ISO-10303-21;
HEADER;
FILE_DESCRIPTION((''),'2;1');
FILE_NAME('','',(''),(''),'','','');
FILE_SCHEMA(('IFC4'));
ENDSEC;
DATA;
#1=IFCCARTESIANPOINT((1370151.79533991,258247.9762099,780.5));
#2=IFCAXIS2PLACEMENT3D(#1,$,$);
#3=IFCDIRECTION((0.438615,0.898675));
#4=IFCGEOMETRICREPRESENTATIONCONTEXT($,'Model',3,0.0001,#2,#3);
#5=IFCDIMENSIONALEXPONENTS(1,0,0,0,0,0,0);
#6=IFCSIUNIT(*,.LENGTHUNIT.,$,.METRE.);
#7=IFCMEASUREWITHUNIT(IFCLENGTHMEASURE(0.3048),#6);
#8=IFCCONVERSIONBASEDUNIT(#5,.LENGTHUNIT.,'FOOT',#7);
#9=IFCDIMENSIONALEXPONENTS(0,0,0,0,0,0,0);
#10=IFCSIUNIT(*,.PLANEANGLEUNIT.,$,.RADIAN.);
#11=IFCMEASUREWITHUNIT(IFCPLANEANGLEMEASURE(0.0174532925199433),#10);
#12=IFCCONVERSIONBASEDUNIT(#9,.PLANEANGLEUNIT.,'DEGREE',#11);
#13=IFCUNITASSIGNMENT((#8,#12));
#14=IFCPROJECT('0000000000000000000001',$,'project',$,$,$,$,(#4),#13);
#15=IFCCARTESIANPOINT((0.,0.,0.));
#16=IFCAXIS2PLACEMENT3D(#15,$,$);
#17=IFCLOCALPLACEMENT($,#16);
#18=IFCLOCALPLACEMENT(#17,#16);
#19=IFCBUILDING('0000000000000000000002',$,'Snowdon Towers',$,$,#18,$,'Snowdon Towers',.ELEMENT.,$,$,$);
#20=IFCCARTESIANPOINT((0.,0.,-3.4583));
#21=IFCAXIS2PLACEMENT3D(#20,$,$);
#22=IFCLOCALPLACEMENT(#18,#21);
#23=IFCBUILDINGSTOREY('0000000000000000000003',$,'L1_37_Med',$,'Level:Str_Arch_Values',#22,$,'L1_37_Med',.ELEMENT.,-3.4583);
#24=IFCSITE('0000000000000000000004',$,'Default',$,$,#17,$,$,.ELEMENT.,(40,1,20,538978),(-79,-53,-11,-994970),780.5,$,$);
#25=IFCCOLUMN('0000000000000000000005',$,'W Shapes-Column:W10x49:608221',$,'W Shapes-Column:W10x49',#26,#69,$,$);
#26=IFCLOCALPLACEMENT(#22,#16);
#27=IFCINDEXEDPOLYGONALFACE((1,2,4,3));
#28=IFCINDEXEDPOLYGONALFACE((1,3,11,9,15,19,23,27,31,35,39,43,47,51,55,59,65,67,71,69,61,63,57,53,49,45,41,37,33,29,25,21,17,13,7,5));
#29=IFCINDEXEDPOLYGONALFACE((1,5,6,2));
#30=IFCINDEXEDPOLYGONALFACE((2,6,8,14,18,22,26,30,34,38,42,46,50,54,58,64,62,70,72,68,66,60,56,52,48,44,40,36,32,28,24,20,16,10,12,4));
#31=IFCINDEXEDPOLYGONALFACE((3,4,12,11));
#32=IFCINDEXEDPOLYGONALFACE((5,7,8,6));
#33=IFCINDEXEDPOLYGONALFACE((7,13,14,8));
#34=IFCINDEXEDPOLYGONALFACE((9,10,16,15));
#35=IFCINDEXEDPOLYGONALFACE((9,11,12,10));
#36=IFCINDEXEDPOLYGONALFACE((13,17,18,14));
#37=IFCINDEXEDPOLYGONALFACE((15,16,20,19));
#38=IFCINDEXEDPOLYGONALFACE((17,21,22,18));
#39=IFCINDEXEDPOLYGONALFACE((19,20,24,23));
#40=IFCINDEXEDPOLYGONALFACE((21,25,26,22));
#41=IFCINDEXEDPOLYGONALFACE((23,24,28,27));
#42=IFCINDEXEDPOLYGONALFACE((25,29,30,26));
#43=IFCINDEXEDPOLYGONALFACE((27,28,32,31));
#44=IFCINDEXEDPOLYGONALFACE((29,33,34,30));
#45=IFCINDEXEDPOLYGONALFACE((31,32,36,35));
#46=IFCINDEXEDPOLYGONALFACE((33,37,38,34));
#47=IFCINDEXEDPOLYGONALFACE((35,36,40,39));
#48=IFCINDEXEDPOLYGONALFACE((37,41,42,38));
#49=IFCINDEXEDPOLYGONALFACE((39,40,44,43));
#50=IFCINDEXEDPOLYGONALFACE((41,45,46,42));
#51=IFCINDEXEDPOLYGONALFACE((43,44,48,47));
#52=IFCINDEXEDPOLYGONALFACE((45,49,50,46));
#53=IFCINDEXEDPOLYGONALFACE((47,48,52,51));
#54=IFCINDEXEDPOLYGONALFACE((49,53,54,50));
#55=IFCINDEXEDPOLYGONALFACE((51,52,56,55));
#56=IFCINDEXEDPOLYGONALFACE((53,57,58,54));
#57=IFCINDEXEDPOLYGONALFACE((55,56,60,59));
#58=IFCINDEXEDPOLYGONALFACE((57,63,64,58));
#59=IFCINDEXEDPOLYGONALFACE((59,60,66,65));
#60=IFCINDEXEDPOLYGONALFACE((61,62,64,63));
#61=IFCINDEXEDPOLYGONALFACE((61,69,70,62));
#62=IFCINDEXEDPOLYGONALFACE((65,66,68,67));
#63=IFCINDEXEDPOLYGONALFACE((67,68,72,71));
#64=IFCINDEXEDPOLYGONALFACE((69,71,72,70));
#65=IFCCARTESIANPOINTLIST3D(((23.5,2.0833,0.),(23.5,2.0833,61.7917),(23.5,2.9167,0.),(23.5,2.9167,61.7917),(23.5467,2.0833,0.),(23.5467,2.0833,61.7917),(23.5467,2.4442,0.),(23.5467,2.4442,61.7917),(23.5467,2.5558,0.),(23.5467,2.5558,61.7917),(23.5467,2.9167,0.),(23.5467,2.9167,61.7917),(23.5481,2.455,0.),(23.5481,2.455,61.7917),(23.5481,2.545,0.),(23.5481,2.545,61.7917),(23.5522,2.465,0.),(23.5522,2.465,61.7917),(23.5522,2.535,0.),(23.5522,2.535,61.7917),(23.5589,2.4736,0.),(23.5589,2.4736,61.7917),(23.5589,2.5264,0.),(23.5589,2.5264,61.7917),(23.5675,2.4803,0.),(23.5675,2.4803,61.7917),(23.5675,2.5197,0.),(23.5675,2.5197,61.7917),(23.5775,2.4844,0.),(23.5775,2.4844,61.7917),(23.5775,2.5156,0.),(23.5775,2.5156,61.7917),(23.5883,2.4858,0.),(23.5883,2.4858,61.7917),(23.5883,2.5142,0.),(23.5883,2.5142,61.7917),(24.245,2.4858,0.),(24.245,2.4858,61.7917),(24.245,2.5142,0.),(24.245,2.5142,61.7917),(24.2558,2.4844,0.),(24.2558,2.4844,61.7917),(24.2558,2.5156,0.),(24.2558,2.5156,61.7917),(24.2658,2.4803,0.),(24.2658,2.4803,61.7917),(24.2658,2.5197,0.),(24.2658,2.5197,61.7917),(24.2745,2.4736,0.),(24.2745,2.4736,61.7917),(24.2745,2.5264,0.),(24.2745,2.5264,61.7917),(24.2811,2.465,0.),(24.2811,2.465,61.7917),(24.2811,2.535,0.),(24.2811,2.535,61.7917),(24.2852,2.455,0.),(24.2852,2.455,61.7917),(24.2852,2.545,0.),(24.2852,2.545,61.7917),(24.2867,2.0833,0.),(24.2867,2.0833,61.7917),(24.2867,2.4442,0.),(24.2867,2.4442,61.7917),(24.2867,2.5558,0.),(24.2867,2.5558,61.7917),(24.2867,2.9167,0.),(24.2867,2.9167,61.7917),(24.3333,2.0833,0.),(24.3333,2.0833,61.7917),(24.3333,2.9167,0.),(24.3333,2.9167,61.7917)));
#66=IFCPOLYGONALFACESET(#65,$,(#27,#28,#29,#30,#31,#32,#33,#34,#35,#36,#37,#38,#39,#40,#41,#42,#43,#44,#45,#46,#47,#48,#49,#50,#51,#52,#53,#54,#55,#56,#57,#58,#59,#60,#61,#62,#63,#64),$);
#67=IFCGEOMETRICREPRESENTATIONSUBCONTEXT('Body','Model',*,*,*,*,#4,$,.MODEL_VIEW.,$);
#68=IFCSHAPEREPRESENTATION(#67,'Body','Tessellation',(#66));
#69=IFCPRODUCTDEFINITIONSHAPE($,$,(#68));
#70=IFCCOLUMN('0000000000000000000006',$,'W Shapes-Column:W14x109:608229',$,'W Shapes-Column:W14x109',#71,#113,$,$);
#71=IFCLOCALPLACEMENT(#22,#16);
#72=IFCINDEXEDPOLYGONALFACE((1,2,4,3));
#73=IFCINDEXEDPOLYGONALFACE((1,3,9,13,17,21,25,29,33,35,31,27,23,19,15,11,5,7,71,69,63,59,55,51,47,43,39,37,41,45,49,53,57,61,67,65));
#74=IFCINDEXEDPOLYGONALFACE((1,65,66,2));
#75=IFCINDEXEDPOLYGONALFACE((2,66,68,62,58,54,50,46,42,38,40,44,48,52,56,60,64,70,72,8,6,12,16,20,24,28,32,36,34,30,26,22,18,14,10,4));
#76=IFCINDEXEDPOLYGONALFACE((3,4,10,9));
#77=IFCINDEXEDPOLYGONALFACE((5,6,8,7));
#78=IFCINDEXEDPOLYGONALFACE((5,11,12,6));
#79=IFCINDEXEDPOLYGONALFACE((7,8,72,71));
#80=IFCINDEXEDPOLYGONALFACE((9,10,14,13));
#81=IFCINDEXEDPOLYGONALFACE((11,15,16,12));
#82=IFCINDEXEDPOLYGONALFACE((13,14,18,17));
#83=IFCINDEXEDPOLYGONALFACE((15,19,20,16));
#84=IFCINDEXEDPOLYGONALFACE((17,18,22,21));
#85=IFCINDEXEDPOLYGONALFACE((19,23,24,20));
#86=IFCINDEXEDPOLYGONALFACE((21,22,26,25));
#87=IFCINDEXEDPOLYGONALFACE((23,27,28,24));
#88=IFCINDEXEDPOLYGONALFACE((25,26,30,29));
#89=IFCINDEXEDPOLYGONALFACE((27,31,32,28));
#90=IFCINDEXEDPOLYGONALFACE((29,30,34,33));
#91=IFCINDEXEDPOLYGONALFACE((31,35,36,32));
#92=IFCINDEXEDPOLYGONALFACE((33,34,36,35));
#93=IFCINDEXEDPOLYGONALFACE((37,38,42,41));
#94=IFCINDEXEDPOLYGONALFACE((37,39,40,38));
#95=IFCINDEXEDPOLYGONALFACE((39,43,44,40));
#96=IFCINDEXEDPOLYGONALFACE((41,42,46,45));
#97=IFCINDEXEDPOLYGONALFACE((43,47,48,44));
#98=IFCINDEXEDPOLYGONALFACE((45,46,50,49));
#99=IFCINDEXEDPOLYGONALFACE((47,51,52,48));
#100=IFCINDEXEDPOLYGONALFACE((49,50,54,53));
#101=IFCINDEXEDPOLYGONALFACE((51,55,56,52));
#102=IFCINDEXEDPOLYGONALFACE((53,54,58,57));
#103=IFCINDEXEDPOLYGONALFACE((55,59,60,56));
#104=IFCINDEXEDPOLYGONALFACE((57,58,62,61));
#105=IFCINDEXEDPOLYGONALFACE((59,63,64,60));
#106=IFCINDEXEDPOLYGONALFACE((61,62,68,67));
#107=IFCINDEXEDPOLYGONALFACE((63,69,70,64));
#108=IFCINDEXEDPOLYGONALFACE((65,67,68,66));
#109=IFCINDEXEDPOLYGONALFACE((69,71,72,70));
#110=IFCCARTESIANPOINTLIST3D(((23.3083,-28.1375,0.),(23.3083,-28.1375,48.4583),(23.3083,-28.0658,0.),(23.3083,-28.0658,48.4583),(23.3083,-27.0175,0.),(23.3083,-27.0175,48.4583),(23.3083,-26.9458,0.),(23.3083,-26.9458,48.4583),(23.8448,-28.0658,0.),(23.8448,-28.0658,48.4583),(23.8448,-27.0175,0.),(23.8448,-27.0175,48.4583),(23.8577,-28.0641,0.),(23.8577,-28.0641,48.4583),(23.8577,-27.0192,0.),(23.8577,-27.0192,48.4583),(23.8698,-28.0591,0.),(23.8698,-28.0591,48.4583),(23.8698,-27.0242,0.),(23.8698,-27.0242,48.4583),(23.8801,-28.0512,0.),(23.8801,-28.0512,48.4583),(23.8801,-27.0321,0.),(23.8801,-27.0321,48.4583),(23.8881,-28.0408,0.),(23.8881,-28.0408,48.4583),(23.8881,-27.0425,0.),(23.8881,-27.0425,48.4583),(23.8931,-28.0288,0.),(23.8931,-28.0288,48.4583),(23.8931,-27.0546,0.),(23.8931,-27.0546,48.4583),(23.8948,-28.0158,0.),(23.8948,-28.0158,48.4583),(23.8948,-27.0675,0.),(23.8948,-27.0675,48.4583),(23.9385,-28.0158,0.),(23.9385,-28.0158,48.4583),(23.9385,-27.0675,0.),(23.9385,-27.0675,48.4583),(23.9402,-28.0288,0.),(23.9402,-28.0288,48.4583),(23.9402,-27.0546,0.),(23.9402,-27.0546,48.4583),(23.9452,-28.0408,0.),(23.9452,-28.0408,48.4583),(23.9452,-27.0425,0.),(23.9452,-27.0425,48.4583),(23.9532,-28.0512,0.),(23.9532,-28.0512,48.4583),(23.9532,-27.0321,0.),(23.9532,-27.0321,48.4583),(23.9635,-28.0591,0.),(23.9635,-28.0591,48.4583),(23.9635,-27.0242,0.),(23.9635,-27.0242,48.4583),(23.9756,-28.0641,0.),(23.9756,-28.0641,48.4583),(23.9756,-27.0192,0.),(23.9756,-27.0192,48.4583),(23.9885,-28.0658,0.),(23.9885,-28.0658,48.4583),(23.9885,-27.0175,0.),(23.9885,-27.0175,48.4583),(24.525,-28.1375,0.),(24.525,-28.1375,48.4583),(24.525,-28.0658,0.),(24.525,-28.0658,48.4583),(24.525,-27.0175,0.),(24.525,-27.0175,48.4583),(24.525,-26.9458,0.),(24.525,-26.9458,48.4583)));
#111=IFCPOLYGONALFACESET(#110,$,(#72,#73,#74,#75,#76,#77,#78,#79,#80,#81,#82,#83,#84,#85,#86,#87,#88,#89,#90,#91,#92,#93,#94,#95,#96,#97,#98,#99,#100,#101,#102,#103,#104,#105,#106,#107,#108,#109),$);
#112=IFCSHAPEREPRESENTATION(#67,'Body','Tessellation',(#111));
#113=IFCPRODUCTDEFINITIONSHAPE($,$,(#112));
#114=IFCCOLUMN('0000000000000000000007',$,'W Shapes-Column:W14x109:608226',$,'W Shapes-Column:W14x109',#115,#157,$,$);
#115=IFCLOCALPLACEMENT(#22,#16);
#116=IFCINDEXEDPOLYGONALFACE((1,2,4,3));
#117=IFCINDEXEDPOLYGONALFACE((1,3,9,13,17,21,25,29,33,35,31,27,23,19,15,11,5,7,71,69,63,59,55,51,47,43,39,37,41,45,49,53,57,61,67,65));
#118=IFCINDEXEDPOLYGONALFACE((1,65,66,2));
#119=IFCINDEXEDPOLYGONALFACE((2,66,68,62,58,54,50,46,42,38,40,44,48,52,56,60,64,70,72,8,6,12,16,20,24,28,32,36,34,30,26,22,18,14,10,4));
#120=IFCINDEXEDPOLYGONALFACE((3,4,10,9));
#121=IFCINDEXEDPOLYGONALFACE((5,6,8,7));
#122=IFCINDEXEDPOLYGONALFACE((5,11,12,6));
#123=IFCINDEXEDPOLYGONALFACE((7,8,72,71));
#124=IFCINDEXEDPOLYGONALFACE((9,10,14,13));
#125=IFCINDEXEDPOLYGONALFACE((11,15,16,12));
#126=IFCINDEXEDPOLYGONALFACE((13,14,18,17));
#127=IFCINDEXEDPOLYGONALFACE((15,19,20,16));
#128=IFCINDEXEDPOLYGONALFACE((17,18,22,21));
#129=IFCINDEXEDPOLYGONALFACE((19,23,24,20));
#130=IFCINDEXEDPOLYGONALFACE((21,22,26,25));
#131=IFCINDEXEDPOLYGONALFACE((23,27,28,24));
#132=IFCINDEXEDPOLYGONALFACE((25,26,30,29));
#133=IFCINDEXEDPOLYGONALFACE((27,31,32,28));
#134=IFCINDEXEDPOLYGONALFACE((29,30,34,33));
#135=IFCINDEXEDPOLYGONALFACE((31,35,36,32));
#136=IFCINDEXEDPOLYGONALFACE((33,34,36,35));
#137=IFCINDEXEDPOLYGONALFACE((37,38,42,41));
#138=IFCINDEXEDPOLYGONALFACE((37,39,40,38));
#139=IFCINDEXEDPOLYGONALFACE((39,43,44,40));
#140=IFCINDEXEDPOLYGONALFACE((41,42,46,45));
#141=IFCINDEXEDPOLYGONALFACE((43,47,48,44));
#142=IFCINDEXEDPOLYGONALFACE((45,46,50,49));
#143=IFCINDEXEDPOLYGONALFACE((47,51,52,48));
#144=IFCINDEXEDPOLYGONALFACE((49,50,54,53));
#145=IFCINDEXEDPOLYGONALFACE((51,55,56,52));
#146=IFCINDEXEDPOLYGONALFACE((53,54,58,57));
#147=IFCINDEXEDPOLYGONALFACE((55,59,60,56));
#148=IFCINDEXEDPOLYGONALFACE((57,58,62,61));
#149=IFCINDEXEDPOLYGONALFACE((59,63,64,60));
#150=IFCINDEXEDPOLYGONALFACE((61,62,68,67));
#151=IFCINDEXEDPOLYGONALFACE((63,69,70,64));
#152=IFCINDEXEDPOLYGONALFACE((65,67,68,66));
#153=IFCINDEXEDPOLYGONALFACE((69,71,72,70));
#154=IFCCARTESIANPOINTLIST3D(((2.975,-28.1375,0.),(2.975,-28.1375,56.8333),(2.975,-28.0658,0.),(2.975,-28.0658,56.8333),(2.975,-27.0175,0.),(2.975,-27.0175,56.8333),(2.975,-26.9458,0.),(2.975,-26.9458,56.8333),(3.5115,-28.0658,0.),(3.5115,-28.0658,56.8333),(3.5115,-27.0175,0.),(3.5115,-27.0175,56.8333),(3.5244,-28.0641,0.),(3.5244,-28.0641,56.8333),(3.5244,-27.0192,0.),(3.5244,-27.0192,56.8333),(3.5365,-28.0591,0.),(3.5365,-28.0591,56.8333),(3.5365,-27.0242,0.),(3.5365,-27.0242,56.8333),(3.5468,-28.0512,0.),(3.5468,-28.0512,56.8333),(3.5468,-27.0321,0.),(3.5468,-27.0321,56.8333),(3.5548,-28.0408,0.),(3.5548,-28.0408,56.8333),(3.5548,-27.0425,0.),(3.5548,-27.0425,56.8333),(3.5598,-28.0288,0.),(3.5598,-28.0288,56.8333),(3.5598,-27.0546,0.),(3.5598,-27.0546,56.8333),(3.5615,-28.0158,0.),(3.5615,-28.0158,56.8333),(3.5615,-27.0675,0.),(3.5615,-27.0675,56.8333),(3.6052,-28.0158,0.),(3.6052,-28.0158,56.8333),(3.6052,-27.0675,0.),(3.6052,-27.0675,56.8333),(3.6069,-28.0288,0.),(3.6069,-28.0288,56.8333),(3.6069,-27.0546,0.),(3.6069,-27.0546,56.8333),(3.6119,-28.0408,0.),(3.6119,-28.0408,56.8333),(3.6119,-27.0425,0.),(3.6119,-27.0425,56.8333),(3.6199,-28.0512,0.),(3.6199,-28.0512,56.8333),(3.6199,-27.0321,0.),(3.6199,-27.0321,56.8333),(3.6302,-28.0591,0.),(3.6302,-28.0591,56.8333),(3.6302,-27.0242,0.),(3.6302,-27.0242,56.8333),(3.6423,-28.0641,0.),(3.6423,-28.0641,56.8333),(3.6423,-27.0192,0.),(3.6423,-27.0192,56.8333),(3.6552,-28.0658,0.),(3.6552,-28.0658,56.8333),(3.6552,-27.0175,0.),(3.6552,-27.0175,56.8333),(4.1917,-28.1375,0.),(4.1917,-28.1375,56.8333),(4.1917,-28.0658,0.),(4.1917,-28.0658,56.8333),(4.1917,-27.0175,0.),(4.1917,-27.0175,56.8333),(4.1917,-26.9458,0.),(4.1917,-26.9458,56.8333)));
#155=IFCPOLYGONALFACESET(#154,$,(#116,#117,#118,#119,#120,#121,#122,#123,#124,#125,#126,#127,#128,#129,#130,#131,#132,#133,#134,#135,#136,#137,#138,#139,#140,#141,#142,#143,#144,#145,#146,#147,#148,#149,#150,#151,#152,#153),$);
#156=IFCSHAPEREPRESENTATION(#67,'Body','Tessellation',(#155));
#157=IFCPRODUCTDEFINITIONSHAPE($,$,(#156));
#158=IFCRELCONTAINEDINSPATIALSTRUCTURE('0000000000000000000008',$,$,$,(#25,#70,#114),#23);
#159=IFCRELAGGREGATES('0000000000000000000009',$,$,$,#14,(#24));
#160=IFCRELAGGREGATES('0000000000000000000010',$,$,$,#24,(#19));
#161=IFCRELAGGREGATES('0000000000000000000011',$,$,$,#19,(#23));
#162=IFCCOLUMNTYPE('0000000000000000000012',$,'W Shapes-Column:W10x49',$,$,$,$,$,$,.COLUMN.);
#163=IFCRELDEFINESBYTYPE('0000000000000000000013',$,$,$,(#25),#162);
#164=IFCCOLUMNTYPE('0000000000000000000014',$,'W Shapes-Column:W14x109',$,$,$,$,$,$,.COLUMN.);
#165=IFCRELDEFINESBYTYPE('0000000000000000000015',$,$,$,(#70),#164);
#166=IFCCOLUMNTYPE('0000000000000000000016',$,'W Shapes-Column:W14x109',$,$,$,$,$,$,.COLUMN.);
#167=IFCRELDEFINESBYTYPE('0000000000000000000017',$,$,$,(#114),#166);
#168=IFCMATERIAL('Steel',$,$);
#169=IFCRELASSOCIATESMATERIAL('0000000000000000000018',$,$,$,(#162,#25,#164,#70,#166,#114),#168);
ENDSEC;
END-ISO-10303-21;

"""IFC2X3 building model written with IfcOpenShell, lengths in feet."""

from ifc_helpers import new_model, entity, si_unit, converted_unit, direction, frame, frame_2d, origin, place, context, subcontext, project, spatial, i_section, extrude, source, transform, mapped, material, type_object, type_shapes, element, save


model = new_model("IFC2X3")

# Units and contexts
model_context = context("Model", 3, precision=0.0001, world=frame((1370151.79533991, 258247.9762099, 780.5)), true_north=direction((0.438615, 0.898675)))
body_context = subcontext(model_context, "Body", "Model", "MODEL_VIEW")
ifc_project = project(units=[converted_unit("LENGTHUNIT", "FOOT", entity("IfcLengthMeasure", 0.3048), si_unit("LENGTHUNIT", "METRE"), dimensions=[1, 0, 0, 0, 0, 0, 0]), converted_unit("PLANEANGLEUNIT", "DEGREE", entity("IfcPlaneAngleMeasure", 0.0174532925199433), si_unit("PLANEANGLEUNIT", "RADIAN"), dimensions=[0, 0, 0, 0, 0, 0, 0])], contexts=[model_context])

# Site, building, storey
site_placement = place(None, origin())
site = spatial("IfcSite", under=ifc_project, at=site_placement, Name="Default", CompositionType="ELEMENT", RefLatitude=(40, 1, 20, 538978), RefLongitude=(-79, -53, -11, -994970), RefElevation=780.5)
building_placement = place(site_placement, origin())
building = spatial("IfcBuilding", under=site, at=building_placement, Name="Snowdon Towers", LongName="Snowdon Towers", CompositionType="ELEMENT")
storey_placement = place(building_placement, frame((0.0, 0.0, -3.4583)))
storey = spatial("IfcBuildingStorey", under=building, at=storey_placement, Name="L1_37_Med", ObjectType="Level:Str_Arch_Values", LongName="L1_37_Med", CompositionType="ELEMENT", Elevation=-3.4583)

# Columns
ifc_material_1 = material(Name="Steel")
column_type_1 = type_object("IfcColumnType", Name="W Shapes-Column:W10x49", PredefinedType="COLUMN", material=ifc_material_1)
shared_shape_1 = source(origin(), body_context, "Body", "SweptSolid", [
    extrude(i_section(OverallWidth=0.8333, OverallDepth=0.8333, WebThickness=0.0283, FlangeThickness=0.0467, FilletRadius=0.0417, at=frame_2d((0.0, 0.0), x_axis=(1.0, 0.0))), frame((0.0, 0.0, -3.4583), z_axis=(0.0, 0.0, 1.0), x_axis=(-1.0, 0.0, 0.0)), (0.0, 0.0, 1.0), 61.7917),
])
type_shapes(column_type_1, [shared_shape_1])
for number, where, z_axis, x_axis, name in (
    (1, (23.9167, 2.5, 3.4583), (0.0, 0.0, 1.0), (0.0, 1.0, 0.0), "W Shapes-Column:W10x49:608221"),
):
    element("IfcColumn", number, at=place(storey_placement, frame(where, z_axis=z_axis, x_axis=x_axis)), inside=storey, type_object=column_type_1, material=ifc_material_1, Name=name, ObjectType="W Shapes-Column:W10x49", context=body_context, shape_type="MappedRepresentation", body=[
        mapped(shared_shape_1, transform((0.0, 0.0, 0.0), scale=1.0)),
    ])
column_type_2 = type_object("IfcColumnType", Name="W Shapes-Column:W14x109", PredefinedType="COLUMN", material=ifc_material_1)
shared_shape_2 = source(origin(), body_context, "Body", "SweptSolid", [
    extrude(i_section(OverallWidth=1.2167, OverallDepth=1.1917, WebThickness=0.0438, FlangeThickness=0.0717, FilletRadius=0.05, at=frame_2d((0.0, 0.0), x_axis=(1.0, 0.0))), frame((0.0, 0.0, -3.4583), z_axis=(0.0, 0.0, 1.0), x_axis=(-1.0, 0.0, 0.0)), (0.0, 0.0, 1.0), 48.4583),
])
type_shapes(column_type_2, [shared_shape_2])
column_1_placement = place(storey_placement, frame((23.9167, -27.5417, 3.4583), z_axis=(0.0, 0.0, 1.0), x_axis=(-1.0, 0.0, 0.0)))
element("IfcColumn", 2, at=column_1_placement, inside=storey, type_object=column_type_2, material=ifc_material_1, Name="W Shapes-Column:W14x109:608229", ObjectType="W Shapes-Column:W14x109", context=body_context, shape_type="MappedRepresentation", body=[
    mapped(shared_shape_2, transform((0.0, 0.0, 0.0), scale=1.0)),
])
column_type_3 = type_object("IfcColumnType", Name="W Shapes-Column:W14x109", PredefinedType="COLUMN", material=ifc_material_1)
shared_shape_3 = source(origin(), body_context, "Body", "SweptSolid", [
    extrude(i_section(OverallWidth=1.2167, OverallDepth=1.1917, WebThickness=0.0438, FlangeThickness=0.0717, FilletRadius=0.05, at=frame_2d((0.0, 0.0), x_axis=(1.0, 0.0))), frame((0.0, 0.0, -3.4583), z_axis=(0.0, 0.0, 1.0), x_axis=(-1.0, 0.0, 0.0)), (0.0, 0.0, 1.0), 56.8333),
])
type_shapes(column_type_3, [shared_shape_3])
column_2_placement = place(storey_placement, frame((3.5833, -27.5417, 3.4583), z_axis=(0.0, 0.0, 1.0), x_axis=(-1.0, 0.0, 0.0)))
element("IfcColumn", 3, at=column_2_placement, inside=storey, type_object=column_type_3, material=ifc_material_1, Name="W Shapes-Column:W14x109:608226", ObjectType="W Shapes-Column:W14x109", context=body_context, shape_type="MappedRepresentation", body=[
    mapped(shared_shape_3, transform((0.0, 0.0, 0.0), scale=1.0)),
])

save(model, "model.ifc")
